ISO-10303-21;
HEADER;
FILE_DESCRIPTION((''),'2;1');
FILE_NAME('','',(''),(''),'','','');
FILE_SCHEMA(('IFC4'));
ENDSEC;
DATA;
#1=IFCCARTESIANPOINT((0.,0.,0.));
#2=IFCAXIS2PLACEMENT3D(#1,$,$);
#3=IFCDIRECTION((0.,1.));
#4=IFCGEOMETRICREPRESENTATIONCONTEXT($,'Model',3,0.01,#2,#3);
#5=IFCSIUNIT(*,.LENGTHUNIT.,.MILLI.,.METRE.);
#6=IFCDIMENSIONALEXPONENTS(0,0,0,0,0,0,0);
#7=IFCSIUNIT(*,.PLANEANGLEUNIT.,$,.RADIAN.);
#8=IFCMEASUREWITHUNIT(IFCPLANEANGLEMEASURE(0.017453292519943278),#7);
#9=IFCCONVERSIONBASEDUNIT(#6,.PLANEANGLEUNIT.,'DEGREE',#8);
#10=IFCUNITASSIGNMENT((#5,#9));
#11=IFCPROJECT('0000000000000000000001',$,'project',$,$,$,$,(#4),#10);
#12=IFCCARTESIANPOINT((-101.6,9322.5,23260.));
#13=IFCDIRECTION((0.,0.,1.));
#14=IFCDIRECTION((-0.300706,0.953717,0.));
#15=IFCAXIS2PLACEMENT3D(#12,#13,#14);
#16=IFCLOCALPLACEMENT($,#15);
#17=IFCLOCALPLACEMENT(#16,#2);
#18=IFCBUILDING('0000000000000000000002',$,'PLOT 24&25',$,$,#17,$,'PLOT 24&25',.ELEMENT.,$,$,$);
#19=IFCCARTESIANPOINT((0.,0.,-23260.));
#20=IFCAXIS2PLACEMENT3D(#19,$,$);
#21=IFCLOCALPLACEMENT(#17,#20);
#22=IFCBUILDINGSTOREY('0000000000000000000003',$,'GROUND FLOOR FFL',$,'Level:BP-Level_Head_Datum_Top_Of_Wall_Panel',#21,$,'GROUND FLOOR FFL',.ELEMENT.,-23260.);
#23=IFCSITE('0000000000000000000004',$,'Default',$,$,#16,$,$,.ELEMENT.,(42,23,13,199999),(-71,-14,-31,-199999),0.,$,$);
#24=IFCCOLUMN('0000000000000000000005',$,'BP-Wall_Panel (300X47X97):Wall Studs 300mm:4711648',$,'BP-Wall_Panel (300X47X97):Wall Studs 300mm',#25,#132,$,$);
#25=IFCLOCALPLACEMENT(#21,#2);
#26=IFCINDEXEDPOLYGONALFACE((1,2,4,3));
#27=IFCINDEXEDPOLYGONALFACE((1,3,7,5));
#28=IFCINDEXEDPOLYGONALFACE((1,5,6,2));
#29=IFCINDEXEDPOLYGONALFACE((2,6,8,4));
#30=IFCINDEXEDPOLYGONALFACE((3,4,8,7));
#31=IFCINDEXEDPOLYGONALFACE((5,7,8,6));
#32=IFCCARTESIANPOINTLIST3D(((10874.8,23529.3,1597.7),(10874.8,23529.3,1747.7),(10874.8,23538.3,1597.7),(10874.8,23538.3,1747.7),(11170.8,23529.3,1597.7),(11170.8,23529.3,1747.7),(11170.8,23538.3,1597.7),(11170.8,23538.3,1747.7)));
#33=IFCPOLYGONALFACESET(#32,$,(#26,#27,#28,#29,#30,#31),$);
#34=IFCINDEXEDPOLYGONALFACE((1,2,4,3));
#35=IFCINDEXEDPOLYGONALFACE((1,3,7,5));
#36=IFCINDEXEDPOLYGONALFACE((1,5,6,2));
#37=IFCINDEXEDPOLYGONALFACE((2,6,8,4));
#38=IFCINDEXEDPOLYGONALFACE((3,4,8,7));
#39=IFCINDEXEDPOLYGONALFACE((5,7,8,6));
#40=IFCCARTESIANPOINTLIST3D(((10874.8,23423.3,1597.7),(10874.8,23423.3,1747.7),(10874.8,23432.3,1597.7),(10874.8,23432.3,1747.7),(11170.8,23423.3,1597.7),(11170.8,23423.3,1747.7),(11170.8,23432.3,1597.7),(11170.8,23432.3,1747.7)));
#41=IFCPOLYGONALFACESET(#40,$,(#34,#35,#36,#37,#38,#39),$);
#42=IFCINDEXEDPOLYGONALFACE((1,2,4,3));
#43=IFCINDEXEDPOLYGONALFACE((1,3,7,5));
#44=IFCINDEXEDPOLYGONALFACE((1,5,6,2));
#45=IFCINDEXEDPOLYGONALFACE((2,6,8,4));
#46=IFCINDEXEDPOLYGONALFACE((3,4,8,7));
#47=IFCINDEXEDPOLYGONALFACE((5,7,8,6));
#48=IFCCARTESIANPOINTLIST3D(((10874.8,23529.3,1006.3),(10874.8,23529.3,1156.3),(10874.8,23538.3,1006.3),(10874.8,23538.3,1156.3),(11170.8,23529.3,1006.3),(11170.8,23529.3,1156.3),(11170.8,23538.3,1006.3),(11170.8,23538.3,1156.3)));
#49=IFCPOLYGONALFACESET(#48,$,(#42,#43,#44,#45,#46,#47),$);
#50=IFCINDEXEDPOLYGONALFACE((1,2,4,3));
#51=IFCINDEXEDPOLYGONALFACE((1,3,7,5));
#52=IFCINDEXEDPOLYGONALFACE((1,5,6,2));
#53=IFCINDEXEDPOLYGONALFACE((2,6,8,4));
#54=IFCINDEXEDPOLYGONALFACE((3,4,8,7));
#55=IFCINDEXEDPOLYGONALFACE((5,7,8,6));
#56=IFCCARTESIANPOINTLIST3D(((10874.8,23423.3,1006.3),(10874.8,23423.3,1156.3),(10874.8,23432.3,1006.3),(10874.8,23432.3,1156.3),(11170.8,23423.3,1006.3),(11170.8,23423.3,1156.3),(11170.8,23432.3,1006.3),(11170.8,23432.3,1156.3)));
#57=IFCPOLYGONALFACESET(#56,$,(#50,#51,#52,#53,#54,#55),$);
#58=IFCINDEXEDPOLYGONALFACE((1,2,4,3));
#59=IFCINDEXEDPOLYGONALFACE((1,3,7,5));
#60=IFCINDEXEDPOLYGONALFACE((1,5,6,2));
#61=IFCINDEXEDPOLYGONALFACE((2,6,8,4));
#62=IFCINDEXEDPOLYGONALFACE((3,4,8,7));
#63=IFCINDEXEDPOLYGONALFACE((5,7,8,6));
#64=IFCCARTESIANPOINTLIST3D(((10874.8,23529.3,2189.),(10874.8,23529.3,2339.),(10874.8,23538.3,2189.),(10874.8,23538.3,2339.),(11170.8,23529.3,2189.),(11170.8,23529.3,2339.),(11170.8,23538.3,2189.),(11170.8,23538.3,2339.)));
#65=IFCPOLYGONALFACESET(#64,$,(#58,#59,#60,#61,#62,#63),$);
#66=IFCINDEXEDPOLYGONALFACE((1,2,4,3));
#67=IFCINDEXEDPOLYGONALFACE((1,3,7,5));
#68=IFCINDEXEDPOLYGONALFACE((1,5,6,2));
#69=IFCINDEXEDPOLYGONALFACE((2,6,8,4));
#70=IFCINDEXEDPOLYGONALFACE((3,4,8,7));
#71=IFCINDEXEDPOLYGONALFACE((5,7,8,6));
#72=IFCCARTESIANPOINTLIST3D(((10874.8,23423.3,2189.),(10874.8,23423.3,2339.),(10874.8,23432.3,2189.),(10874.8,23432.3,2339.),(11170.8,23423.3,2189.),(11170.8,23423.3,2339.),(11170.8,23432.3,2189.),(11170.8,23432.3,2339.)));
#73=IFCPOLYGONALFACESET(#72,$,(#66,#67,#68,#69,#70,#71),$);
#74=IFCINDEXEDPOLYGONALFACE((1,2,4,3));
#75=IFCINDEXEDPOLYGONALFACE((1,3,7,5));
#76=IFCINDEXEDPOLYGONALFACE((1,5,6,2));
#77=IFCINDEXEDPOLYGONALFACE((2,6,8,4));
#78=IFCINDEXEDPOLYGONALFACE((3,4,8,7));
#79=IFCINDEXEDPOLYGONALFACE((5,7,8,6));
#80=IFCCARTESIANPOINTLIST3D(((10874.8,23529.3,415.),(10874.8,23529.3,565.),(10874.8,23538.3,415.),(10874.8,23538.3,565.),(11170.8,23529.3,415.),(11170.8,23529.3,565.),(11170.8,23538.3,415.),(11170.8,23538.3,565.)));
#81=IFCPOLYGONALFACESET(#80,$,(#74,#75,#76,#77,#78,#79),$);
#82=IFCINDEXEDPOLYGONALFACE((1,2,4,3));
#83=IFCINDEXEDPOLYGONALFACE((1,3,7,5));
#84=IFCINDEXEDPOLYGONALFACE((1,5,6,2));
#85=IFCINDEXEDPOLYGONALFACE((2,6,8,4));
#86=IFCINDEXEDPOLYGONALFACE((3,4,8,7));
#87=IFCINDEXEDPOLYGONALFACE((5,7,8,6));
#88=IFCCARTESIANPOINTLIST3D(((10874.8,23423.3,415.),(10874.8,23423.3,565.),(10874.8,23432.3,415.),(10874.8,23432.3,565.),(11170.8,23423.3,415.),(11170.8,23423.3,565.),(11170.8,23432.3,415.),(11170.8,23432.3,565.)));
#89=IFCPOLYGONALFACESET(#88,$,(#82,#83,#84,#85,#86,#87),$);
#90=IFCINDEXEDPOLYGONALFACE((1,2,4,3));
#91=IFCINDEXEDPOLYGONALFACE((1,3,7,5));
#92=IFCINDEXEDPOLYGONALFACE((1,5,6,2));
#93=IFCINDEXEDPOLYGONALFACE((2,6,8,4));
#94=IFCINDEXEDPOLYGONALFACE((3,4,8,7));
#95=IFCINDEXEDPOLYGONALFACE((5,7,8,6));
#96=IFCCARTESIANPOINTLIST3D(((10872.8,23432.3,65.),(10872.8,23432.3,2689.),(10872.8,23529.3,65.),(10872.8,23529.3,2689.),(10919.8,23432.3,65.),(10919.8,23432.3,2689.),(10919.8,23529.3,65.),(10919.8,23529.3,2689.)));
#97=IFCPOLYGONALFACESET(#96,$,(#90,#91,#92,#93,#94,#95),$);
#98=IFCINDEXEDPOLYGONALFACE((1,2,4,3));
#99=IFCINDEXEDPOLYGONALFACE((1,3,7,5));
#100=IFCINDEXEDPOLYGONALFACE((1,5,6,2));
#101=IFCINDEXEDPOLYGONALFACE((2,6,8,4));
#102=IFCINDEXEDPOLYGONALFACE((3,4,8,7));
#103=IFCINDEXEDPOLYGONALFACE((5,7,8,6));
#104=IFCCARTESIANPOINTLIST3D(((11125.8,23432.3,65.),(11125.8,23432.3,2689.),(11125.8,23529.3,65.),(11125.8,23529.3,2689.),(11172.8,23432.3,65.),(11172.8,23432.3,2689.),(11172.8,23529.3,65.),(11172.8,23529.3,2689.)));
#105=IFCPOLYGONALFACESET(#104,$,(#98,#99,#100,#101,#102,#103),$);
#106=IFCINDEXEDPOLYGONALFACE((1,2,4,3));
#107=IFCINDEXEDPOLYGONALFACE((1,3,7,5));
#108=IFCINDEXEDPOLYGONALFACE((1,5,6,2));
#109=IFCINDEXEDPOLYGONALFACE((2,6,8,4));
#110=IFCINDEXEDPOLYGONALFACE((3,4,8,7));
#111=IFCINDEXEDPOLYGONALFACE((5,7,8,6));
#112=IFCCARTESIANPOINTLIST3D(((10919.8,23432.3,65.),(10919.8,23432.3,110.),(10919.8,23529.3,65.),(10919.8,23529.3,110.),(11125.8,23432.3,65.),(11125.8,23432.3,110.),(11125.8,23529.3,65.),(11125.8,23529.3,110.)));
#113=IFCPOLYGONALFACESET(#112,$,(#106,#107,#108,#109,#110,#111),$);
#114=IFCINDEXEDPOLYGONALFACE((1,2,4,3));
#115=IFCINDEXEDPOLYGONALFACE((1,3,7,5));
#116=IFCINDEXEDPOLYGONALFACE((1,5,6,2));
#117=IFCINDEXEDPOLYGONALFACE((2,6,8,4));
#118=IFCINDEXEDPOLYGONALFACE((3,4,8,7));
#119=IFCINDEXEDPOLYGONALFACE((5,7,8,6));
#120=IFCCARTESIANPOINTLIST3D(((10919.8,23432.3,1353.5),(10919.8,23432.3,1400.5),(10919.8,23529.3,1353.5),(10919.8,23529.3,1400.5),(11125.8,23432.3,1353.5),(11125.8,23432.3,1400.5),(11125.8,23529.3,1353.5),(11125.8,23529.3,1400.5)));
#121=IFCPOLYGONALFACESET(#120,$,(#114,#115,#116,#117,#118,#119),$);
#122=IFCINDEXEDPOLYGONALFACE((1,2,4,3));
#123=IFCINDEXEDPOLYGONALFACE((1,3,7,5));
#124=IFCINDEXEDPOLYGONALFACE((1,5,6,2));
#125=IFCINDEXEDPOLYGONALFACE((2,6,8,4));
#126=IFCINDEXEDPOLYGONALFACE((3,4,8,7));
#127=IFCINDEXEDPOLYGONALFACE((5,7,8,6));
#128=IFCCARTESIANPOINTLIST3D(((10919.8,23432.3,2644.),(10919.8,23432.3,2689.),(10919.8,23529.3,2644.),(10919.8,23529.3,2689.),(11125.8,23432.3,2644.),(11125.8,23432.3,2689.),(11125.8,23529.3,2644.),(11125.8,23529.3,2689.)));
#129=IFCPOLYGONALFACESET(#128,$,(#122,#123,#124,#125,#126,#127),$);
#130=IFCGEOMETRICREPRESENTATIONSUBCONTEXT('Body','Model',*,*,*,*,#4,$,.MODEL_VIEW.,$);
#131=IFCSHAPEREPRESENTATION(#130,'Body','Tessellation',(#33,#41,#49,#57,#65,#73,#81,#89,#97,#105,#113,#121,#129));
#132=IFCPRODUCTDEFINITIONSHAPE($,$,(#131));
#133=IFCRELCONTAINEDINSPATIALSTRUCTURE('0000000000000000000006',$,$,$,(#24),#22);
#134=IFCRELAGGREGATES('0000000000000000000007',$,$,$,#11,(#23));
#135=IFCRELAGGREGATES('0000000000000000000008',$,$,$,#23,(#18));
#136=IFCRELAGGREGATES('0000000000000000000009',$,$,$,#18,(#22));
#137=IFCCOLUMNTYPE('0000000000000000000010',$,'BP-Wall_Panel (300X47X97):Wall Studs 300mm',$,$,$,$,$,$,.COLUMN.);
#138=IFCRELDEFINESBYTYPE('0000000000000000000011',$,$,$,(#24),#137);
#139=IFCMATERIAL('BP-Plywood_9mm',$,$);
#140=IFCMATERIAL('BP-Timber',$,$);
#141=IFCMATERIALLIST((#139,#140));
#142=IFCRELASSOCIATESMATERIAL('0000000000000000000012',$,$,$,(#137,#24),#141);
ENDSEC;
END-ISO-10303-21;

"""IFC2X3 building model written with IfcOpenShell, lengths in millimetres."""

from ifc_helpers import new_model, entity, si_unit, converted_unit, direction, frame, frame_2d, origin, origin_2d_with_axis, place, context, subcontext, project, spatial, rectangle, extrude, source, transform, mapped, material, material_list, type_object, type_shapes, element, save


model = new_model("IFC2X3")

# Units and contexts
model_context = context("Model", 3, precision=0.01, world=origin(), true_north=direction((0.0, 1.0)))
body_context = subcontext(model_context, "Body", "Model", "MODEL_VIEW")
ifc_project = project(units=[si_unit("LENGTHUNIT", "METRE", prefix="MILLI"), converted_unit("PLANEANGLEUNIT", "DEGREE", entity("IfcPlaneAngleMeasure", 0.017453292519943278), si_unit("PLANEANGLEUNIT", "RADIAN"), dimensions=[0, 0, 0, 0, 0, 0, 0])], contexts=[model_context])

# Site, building, storey
site_placement = place(None, frame((-101.6, 9322.5, 23260.0), z_axis=(0.0, 0.0, 1.0), x_axis=(-0.300706, 0.953717, 0.0)))
site = spatial("IfcSite", under=ifc_project, at=site_placement, Name="Default", CompositionType="ELEMENT", RefLatitude=(42, 23, 13, 199999), RefLongitude=(-71, -14, -31, -199999), RefElevation=0.0)
building_placement = place(site_placement, origin())
building = spatial("IfcBuilding", under=site, at=building_placement, Name="PLOT 24&25", LongName="PLOT 24&25", CompositionType="ELEMENT")
storey_placement = place(building_placement, frame((0.0, 0.0, -23260.0)))
storey = spatial("IfcBuildingStorey", under=building, at=storey_placement, Name="GROUND FLOOR FFL", ObjectType="Level:BP-Level_Head_Datum_Top_Of_Wall_Panel", LongName="GROUND FLOOR FFL", CompositionType="ELEMENT", Elevation=-23260.0)

# Column
ifc_material_1 = material(Name="BP-Plywood_9mm")
ifc_material_2 = material(Name="BP-Timber")
ifc_material_list = material_list([ifc_material_1, ifc_material_2])
column_type_1 = type_object("IfcColumnType", Name="BP-Wall_Panel (300X47X97):Wall Studs 300mm", PredefinedType="COLUMN", material=ifc_material_list)
shared_shape_1 = source(origin(), body_context, "Body", "SweptSolid", [
    extrude(rectangle(XDim=9.0, YDim=296.0, at=origin_2d_with_axis()), frame((53.0, 0.0, -21662.3)), (0.0, 0.0, 1.0), 150.0),
    extrude(rectangle(XDim=296.0, YDim=9.0, at=origin_2d_with_axis()), frame((-53.0, 0.0, -21662.3), z_axis=(0.0, 0.0, 1.0), x_axis=(0.0, 1.0, 0.0)), (0.0, 0.0, 1.0), 150.0),
    extrude(rectangle(XDim=9.0, YDim=296.0, at=origin_2d_with_axis()), frame((53.0, 0.0, -22253.7)), (0.0, 0.0, 1.0), 150.0),
    extrude(rectangle(XDim=296.0, YDim=9.0, at=origin_2d_with_axis()), frame((-53.0, 0.0, -22253.7), z_axis=(0.0, 0.0, 1.0), x_axis=(0.0, 1.0, 0.0)), (0.0, 0.0, 1.0), 150.0),
    extrude(rectangle(XDim=9.0, YDim=296.0, at=origin_2d_with_axis()), frame((53.0, 0.0, -21071.0)), (0.0, 0.0, 1.0), 150.0),
    extrude(rectangle(XDim=296.0, YDim=9.0, at=origin_2d_with_axis()), frame((-53.0, 0.0, -21071.0), z_axis=(0.0, 0.0, 1.0), x_axis=(0.0, 1.0, 0.0)), (0.0, 0.0, 1.0), 150.0),
    extrude(rectangle(XDim=9.0, YDim=296.0, at=origin_2d_with_axis()), frame((53.0, 0.0, -22845.0)), (0.0, 0.0, 1.0), 150.0),
    extrude(rectangle(XDim=296.0, YDim=9.0, at=origin_2d_with_axis()), frame((-53.0, 0.0, -22845.0), z_axis=(0.0, 0.0, 1.0), x_axis=(0.0, 1.0, 0.0)), (0.0, 0.0, 1.0), 150.0),
    extrude(rectangle(XDim=47.0, YDim=97.0, at=origin_2d_with_axis()), frame((0.0, 126.5, -23195.0), z_axis=(0.0, 0.0, 1.0), x_axis=(0.0, 1.0, 0.0)), (0.0, 0.0, 1.0), 2624.0),
    extrude(rectangle(XDim=47.0, YDim=97.0, at=frame_2d((0.0, 0.0), x_axis=(1.0, 0.0))), frame((0.0, -126.5, -23195.0), z_axis=(0.0, 0.0, 1.0), x_axis=(0.0, 1.0, 0.0)), (0.0, 0.0, 1.0), 2624.0),
    extrude(rectangle(XDim=97.0, YDim=206.0, at=origin_2d_with_axis()), frame((0.0, 0.0, -23195.0)), (0.0, 0.0, 1.0), 45.0),
    extrude(rectangle(XDim=97.0, YDim=206.0, at=origin_2d_with_axis()), frame((0.0, 0.0, -21906.5)), (0.0, 0.0, 1.0), 47.0),
    extrude(rectangle(XDim=97.0, YDim=206.0, at=origin_2d_with_axis()), frame((0.0, 0.0, -20616.0)), (0.0, 0.0, 1.0), 45.0),
])
type_shapes(column_type_1, [shared_shape_1])
for number, where, z_axis, x_axis, name in (
    (1, (11022.8, 23480.8, 23260.0), (0.0, 0.0, 1.0), (0.0, 1.0, 0.0), "BP-Wall_Panel (300X47X97):Wall Studs 300mm:4711648"),
):
    element("IfcColumn", number, at=place(storey_placement, frame(where, z_axis=z_axis, x_axis=x_axis)), inside=storey, type_object=column_type_1, material=ifc_material_list, Name=name, ObjectType="BP-Wall_Panel (300X47X97):Wall Studs 300mm", context=body_context, shape_type="MappedRepresentation", body=[
        mapped(shared_shape_1, transform((0.0, 0.0, 0.0), scale=1.0)),
    ])

save(model, "model.ifc")
